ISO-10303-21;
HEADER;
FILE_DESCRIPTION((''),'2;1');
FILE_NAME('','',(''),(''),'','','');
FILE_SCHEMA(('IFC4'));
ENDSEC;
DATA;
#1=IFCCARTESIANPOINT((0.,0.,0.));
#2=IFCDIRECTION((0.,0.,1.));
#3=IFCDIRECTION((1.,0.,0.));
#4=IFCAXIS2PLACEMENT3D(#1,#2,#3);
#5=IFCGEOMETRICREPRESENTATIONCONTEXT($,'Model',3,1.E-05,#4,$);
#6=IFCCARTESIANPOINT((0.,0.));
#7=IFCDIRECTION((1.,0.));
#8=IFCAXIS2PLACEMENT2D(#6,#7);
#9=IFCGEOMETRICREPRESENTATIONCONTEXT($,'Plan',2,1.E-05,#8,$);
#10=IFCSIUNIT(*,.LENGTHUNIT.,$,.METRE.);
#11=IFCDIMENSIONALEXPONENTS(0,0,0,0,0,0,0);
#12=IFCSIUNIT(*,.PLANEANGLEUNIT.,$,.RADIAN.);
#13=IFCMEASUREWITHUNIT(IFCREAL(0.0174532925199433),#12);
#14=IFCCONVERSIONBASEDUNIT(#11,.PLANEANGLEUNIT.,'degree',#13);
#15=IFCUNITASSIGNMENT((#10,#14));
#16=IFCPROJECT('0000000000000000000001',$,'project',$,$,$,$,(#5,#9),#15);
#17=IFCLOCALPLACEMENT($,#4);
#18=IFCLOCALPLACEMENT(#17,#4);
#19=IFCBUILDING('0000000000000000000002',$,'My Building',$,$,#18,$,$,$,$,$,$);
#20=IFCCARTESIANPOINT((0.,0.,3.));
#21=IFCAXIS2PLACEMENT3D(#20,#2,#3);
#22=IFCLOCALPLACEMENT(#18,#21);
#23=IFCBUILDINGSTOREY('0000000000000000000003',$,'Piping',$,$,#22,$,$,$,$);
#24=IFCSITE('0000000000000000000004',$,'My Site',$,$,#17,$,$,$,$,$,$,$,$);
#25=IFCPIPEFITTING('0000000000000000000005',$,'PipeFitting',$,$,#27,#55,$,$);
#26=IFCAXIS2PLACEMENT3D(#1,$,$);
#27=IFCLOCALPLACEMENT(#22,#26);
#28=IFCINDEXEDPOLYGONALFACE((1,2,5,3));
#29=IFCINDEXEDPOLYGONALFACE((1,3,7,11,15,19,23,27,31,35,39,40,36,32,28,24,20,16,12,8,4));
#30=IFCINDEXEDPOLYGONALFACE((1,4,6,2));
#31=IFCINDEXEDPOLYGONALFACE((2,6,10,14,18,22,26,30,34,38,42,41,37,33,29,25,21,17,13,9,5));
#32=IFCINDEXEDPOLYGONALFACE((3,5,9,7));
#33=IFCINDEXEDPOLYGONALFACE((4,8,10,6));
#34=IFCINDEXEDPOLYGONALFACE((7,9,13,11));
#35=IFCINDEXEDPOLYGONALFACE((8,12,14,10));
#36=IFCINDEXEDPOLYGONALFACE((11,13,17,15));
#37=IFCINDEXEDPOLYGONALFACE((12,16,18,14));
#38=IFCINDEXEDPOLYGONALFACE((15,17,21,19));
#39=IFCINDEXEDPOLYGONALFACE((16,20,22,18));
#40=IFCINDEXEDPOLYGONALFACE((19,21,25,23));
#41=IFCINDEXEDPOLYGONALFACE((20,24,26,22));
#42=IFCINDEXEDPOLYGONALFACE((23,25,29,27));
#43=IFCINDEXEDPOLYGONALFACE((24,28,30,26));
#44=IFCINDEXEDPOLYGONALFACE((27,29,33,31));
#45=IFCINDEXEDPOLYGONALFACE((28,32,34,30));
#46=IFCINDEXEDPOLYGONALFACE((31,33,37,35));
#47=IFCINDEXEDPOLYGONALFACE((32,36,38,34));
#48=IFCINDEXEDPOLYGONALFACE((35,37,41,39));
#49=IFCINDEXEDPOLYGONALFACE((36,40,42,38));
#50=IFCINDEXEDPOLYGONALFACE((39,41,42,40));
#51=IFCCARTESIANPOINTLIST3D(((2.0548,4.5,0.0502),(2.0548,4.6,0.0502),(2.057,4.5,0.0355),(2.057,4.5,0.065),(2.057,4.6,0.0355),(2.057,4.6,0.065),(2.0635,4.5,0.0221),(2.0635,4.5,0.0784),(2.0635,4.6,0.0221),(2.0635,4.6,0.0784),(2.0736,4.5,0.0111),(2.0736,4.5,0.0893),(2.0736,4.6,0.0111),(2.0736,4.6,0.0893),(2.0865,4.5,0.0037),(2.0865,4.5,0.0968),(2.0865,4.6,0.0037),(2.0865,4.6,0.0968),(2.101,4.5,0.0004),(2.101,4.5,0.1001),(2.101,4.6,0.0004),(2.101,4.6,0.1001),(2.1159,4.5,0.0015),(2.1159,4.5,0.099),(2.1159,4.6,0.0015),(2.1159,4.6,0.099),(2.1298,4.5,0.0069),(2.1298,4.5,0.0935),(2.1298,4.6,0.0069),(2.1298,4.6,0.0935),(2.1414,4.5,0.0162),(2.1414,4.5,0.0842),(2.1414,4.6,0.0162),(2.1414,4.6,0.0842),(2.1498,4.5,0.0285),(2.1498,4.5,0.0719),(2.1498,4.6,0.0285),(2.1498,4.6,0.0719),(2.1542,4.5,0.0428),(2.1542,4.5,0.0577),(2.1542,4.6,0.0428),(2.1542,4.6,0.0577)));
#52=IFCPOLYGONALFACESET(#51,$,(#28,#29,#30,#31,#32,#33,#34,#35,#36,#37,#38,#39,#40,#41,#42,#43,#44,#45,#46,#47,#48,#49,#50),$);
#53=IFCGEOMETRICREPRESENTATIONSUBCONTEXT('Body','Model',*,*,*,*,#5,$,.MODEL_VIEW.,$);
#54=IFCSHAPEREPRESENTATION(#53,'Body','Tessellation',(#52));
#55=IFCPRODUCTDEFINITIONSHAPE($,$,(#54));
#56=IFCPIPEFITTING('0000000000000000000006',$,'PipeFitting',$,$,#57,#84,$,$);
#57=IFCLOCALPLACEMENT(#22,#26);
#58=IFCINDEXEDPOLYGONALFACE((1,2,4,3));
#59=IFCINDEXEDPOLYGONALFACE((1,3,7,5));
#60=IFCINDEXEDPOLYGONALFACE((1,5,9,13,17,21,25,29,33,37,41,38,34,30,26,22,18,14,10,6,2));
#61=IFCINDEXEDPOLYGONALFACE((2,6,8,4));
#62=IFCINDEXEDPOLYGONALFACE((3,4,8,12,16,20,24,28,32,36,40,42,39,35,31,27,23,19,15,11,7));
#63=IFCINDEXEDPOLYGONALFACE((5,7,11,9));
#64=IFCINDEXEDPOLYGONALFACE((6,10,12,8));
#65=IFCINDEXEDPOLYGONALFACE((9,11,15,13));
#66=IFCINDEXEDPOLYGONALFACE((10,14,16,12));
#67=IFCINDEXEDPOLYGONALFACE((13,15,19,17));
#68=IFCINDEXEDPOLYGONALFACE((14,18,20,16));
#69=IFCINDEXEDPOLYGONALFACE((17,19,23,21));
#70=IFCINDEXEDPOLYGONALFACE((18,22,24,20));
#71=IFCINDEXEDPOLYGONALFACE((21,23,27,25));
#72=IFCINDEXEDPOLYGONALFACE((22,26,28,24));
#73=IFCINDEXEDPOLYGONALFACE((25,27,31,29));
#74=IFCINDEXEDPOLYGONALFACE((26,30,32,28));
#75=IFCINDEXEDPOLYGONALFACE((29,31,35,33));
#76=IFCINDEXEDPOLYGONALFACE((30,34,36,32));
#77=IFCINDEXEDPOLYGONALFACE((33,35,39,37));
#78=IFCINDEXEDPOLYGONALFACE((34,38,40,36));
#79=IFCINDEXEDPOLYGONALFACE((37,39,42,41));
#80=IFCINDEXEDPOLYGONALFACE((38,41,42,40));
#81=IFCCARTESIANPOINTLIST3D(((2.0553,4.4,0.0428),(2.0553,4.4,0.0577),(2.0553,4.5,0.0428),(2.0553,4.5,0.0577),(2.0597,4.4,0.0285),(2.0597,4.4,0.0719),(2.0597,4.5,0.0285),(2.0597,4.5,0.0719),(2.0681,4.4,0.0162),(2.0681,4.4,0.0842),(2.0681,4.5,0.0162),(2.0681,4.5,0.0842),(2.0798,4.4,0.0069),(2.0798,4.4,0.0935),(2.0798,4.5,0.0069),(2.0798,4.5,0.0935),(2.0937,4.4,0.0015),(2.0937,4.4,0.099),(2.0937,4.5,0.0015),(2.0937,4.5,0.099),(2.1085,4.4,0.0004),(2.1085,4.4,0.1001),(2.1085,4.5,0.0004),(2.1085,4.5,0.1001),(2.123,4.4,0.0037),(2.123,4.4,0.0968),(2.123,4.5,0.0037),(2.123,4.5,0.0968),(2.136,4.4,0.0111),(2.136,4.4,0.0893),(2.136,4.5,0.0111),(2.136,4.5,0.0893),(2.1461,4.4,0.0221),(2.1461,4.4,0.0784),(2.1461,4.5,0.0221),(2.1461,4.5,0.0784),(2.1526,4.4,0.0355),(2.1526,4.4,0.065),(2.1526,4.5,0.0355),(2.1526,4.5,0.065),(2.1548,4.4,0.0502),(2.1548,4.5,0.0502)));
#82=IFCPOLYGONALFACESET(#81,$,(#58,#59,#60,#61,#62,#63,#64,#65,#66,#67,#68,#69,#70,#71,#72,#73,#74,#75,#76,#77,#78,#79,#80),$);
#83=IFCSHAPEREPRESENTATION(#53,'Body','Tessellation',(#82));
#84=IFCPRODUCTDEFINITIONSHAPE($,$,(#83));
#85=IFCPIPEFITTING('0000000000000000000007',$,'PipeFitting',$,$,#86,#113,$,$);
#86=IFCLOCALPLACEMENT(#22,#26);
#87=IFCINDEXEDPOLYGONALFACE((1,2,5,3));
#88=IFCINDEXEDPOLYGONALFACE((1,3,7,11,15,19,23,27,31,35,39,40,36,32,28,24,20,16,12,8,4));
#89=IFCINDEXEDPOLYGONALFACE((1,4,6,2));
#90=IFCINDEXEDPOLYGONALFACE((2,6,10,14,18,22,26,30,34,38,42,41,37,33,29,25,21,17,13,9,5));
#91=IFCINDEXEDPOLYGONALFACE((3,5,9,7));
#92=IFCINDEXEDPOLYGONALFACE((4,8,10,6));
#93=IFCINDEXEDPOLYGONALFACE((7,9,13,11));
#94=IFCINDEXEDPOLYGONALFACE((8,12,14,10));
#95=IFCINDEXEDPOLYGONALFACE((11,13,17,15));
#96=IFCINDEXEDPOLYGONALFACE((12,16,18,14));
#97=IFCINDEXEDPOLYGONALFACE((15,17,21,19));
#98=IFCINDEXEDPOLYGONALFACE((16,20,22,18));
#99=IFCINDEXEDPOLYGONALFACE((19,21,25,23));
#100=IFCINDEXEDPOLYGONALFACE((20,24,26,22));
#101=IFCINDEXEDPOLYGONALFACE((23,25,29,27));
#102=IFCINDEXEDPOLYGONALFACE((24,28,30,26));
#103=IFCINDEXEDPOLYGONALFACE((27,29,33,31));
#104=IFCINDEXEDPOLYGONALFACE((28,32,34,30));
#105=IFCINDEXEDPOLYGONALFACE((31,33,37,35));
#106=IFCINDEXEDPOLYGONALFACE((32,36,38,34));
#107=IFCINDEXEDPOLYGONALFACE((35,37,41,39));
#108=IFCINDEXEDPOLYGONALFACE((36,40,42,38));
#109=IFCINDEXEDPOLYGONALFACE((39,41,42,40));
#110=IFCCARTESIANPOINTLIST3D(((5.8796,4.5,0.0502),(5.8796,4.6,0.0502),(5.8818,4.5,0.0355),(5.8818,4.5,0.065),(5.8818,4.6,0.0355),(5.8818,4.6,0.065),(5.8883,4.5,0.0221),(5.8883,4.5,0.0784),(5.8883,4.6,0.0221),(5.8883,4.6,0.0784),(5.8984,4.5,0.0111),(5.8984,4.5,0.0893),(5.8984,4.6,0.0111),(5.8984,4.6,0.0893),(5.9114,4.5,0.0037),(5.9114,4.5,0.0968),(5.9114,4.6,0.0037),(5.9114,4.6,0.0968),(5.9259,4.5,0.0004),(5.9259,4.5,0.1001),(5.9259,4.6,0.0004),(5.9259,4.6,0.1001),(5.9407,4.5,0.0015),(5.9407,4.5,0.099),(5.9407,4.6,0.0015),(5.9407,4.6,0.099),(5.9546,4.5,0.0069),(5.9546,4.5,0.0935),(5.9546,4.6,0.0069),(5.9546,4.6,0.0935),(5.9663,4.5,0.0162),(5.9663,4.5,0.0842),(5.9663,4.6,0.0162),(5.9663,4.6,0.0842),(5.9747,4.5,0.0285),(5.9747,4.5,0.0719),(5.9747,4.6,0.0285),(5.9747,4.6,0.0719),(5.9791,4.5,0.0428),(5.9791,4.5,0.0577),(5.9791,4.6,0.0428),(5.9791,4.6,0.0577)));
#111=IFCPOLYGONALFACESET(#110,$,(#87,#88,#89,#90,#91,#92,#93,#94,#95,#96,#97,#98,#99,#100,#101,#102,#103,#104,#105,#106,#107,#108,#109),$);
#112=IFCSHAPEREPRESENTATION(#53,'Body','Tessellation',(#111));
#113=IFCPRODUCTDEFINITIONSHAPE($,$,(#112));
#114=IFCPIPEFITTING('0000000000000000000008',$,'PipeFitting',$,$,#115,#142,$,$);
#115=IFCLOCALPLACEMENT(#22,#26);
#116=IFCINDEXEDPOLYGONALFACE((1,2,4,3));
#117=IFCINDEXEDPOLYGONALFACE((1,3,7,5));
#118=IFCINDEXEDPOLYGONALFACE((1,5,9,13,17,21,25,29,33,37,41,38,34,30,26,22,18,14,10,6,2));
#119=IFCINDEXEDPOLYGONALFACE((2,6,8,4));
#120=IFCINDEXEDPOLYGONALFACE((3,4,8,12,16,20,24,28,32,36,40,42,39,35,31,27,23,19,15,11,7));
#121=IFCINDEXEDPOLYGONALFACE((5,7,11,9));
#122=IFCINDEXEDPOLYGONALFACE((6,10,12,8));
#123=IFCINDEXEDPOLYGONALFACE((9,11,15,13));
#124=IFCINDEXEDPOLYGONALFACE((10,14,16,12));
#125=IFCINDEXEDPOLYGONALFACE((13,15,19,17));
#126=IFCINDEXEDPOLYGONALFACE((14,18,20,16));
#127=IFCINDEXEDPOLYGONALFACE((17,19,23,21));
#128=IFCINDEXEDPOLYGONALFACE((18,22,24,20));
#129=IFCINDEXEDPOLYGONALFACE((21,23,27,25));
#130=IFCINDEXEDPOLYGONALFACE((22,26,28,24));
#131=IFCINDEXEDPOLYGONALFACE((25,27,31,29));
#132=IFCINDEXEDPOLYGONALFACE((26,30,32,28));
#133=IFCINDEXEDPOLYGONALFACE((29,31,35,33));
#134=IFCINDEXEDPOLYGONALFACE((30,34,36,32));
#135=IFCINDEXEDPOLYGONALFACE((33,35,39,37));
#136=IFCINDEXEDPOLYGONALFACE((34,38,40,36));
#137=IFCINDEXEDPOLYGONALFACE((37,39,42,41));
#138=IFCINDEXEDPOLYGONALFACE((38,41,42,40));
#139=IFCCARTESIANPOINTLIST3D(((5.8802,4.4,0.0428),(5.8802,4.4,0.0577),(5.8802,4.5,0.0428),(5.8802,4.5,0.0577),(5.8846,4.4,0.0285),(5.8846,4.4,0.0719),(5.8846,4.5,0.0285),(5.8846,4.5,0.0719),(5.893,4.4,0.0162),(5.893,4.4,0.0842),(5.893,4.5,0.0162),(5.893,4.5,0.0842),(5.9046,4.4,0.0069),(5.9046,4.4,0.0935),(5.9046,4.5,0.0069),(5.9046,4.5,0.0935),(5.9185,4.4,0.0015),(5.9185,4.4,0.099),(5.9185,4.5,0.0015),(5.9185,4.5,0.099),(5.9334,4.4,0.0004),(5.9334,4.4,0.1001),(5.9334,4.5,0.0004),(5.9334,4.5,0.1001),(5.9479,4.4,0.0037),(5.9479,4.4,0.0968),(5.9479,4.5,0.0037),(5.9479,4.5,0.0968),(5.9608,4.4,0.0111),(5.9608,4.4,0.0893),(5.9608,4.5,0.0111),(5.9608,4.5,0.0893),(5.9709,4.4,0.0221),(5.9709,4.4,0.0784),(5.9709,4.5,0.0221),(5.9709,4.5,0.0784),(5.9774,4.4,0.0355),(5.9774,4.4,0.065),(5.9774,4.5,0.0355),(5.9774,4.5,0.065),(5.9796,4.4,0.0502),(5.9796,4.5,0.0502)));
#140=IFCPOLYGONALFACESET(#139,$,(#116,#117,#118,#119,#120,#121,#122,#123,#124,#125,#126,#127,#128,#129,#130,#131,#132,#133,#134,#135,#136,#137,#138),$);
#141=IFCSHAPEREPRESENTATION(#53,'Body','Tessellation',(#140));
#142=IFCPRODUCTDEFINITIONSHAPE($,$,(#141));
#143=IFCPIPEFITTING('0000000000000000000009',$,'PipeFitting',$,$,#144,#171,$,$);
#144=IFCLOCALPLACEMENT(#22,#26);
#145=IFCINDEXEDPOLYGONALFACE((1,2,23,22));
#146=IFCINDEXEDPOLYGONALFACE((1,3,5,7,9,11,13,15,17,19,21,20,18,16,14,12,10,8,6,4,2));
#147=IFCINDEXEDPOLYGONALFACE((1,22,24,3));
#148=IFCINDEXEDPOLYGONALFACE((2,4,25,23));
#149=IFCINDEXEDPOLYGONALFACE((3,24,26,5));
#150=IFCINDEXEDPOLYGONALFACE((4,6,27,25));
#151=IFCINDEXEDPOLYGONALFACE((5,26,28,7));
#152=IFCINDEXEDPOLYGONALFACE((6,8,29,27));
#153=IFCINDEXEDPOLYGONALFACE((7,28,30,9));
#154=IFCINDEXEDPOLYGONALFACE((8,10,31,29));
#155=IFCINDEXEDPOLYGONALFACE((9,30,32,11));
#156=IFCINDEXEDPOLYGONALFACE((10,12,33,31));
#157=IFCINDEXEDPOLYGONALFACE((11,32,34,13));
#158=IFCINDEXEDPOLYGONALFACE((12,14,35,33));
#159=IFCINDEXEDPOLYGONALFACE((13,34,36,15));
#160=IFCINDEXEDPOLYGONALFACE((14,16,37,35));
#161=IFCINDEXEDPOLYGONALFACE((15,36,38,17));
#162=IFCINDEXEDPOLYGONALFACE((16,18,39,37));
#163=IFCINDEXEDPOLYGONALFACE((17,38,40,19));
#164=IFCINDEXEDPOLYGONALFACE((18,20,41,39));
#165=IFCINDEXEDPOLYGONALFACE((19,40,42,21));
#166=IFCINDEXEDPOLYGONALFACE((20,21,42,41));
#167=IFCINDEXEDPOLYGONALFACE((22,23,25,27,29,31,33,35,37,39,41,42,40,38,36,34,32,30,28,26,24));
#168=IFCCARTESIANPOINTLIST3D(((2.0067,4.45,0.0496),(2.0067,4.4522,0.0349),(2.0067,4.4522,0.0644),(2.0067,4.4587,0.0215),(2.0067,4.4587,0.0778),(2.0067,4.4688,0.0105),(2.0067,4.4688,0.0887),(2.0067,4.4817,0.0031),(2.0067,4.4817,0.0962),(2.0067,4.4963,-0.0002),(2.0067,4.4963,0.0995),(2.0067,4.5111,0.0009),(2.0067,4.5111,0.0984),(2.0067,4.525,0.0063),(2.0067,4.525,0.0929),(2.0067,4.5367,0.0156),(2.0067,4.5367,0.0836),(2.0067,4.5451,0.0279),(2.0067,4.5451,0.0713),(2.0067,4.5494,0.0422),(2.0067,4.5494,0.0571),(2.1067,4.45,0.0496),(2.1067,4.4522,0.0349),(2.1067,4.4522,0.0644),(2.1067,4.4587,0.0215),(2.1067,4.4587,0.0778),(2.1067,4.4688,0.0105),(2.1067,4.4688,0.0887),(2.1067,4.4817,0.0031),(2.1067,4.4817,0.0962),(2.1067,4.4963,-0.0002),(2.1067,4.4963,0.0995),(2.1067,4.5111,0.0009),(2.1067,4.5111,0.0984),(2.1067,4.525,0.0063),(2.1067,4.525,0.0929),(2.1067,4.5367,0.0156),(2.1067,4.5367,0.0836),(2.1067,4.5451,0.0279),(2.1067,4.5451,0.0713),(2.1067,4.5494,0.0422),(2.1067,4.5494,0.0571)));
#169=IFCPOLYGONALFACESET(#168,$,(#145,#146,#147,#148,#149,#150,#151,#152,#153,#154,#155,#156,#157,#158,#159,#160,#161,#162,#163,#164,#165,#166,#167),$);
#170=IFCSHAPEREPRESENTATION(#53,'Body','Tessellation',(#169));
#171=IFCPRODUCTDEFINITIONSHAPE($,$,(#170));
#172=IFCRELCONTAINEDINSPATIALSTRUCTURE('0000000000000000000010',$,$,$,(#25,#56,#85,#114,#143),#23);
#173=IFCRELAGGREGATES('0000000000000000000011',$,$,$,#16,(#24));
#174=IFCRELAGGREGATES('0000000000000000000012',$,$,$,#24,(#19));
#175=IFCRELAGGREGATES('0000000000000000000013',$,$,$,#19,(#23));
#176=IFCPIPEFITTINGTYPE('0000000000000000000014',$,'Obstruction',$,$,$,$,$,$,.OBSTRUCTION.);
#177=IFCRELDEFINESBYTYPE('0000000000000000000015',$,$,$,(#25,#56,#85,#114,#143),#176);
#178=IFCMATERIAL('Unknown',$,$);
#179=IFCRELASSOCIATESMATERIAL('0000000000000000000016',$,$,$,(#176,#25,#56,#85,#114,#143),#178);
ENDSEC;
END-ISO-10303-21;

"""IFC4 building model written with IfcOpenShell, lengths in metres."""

from ifc_helpers import new_model, entity, si_unit, converted_unit, frame, origin_with_axes, origin_2d_with_axis, place, context, subcontext, project, spatial, circle, extrude, material, material_profile, profile_set, profile_usage, type_object, element, save


model = new_model("IFC4")

# Units and contexts
model_context = context("Model", 3, precision=1e-05, world=origin_with_axes())
plan_context = context("Plan", 2, precision=1e-05, world=origin_2d_with_axis())
body_context = subcontext(model_context, "Body", "Model", "MODEL_VIEW")
ifc_project = project(units=[si_unit("LENGTHUNIT", "METRE"), converted_unit("PLANEANGLEUNIT", "degree", entity("IfcReal", 0.0174532925199433), si_unit("PLANEANGLEUNIT", "RADIAN"), dimensions=[0, 0, 0, 0, 0, 0, 0])], contexts=[model_context, plan_context])

# Site, building, storey
site_placement = place(None, origin_with_axes())
site = spatial("IfcSite", under=ifc_project, at=site_placement, Name="My Site")
building_placement = place(site_placement, origin_with_axes())
building = spatial("IfcBuilding", under=site, at=building_placement, Name="My Building")
storey_placement = place(building_placement, frame((0.0, 0.0, 3.0), z_axis=(0.0, 0.0, 1.0), x_axis=(1.0, 0.0, 0.0)))
storey = spatial("IfcBuildingStorey", under=building, at=storey_placement, Name="Piping")

# Shared definitions
ifc_material = material(Name="Unknown")

# Pipe fittings
ifc_material_profile_1 = material_profile(ifc_material, circle(Radius=0.05))
ifc_profile_set_1 = profile_set([ifc_material_profile_1])
ifc_profile_usage_1 = profile_usage(ifc_profile_set_1, cardinal=5)
pipe_fitting_type_1 = type_object("IfcPipeFittingType", Name="Obstruction", PredefinedType="OBSTRUCTION", material=ifc_profile_set_1)
pipe_fitting_1_placement = place(storey_placement, frame((2.1048, 4.5, 0.0502), z_axis=(0.0, 1.0, 0.000006), x_axis=(-1.0, 0.0, 0.0)))
element("IfcPipeFitting", 1, at=pipe_fitting_1_placement, inside=storey, type_object=pipe_fitting_type_1, material=ifc_profile_usage_1, Name="PipeFitting", context=body_context, shape_type="SweptSolid", body=[
    extrude(circle(Radius=0.05), origin_with_axes(), (0.0, 0.0, 1.0), 0.1),
])
ifc_profile_usage_2 = profile_usage(ifc_profile_set_1, cardinal=5)
pipe_fitting_2_placement = place(storey_placement, frame((2.1048, 4.5, 0.0502), z_axis=(0.0, -1.0, 0.000006), x_axis=(1.0, 0.0, 0.0)))
element("IfcPipeFitting", 2, at=pipe_fitting_2_placement, inside=storey, type_object=pipe_fitting_type_1, material=ifc_profile_usage_2, Name="PipeFitting", context=body_context, shape_type="SweptSolid", body=[
    extrude(circle(Radius=0.05), origin_with_axes(), (0.0, 0.0, 1.0), 0.1),
])
ifc_profile_usage_3 = profile_usage(ifc_profile_set_1, cardinal=5)
pipe_fitting_3_placement = place(storey_placement, frame((5.9296, 4.5, 0.0502), z_axis=(0.0, 1.0, 0.000006), x_axis=(-1.0, 0.0, 0.0)))
element("IfcPipeFitting", 3, at=pipe_fitting_3_placement, inside=storey, type_object=pipe_fitting_type_1, material=ifc_profile_usage_3, Name="PipeFitting", context=body_context, shape_type="SweptSolid", body=[
    extrude(circle(Radius=0.05), origin_with_axes(), (0.0, 0.0, 1.0), 0.1),
])
ifc_profile_usage_4 = profile_usage(ifc_profile_set_1, cardinal=5)
pipe_fitting_4_placement = place(storey_placement, frame((5.9296, 4.5, 0.0502), z_axis=(0.0, -1.0, 0.000006), x_axis=(1.0, 0.0, 0.0)))
element("IfcPipeFitting", 4, at=pipe_fitting_4_placement, inside=storey, type_object=pipe_fitting_type_1, material=ifc_profile_usage_4, Name="PipeFitting", context=body_context, shape_type="SweptSolid", body=[
    extrude(circle(Radius=0.05), origin_with_axes(), (0.0, 0.0, 1.0), 0.1),
])
ifc_profile_usage_5 = profile_usage(ifc_profile_set_1, cardinal=5)
pipe_fitting_5_placement = place(storey_placement, frame((2.1067, 4.5, 0.0496), z_axis=(-1.0, 0.0, 0.0), x_axis=(0.0, -1.0, 0.0)))
element("IfcPipeFitting", 5, at=pipe_fitting_5_placement, inside=storey, type_object=pipe_fitting_type_1, material=ifc_profile_usage_5, Name="PipeFitting", context=body_context, shape_type="SweptSolid", body=[
    extrude(circle(Radius=0.05), origin_with_axes(), (0.0, 0.0, 1.0), 0.1),
])

save(model, "model.ifc")
